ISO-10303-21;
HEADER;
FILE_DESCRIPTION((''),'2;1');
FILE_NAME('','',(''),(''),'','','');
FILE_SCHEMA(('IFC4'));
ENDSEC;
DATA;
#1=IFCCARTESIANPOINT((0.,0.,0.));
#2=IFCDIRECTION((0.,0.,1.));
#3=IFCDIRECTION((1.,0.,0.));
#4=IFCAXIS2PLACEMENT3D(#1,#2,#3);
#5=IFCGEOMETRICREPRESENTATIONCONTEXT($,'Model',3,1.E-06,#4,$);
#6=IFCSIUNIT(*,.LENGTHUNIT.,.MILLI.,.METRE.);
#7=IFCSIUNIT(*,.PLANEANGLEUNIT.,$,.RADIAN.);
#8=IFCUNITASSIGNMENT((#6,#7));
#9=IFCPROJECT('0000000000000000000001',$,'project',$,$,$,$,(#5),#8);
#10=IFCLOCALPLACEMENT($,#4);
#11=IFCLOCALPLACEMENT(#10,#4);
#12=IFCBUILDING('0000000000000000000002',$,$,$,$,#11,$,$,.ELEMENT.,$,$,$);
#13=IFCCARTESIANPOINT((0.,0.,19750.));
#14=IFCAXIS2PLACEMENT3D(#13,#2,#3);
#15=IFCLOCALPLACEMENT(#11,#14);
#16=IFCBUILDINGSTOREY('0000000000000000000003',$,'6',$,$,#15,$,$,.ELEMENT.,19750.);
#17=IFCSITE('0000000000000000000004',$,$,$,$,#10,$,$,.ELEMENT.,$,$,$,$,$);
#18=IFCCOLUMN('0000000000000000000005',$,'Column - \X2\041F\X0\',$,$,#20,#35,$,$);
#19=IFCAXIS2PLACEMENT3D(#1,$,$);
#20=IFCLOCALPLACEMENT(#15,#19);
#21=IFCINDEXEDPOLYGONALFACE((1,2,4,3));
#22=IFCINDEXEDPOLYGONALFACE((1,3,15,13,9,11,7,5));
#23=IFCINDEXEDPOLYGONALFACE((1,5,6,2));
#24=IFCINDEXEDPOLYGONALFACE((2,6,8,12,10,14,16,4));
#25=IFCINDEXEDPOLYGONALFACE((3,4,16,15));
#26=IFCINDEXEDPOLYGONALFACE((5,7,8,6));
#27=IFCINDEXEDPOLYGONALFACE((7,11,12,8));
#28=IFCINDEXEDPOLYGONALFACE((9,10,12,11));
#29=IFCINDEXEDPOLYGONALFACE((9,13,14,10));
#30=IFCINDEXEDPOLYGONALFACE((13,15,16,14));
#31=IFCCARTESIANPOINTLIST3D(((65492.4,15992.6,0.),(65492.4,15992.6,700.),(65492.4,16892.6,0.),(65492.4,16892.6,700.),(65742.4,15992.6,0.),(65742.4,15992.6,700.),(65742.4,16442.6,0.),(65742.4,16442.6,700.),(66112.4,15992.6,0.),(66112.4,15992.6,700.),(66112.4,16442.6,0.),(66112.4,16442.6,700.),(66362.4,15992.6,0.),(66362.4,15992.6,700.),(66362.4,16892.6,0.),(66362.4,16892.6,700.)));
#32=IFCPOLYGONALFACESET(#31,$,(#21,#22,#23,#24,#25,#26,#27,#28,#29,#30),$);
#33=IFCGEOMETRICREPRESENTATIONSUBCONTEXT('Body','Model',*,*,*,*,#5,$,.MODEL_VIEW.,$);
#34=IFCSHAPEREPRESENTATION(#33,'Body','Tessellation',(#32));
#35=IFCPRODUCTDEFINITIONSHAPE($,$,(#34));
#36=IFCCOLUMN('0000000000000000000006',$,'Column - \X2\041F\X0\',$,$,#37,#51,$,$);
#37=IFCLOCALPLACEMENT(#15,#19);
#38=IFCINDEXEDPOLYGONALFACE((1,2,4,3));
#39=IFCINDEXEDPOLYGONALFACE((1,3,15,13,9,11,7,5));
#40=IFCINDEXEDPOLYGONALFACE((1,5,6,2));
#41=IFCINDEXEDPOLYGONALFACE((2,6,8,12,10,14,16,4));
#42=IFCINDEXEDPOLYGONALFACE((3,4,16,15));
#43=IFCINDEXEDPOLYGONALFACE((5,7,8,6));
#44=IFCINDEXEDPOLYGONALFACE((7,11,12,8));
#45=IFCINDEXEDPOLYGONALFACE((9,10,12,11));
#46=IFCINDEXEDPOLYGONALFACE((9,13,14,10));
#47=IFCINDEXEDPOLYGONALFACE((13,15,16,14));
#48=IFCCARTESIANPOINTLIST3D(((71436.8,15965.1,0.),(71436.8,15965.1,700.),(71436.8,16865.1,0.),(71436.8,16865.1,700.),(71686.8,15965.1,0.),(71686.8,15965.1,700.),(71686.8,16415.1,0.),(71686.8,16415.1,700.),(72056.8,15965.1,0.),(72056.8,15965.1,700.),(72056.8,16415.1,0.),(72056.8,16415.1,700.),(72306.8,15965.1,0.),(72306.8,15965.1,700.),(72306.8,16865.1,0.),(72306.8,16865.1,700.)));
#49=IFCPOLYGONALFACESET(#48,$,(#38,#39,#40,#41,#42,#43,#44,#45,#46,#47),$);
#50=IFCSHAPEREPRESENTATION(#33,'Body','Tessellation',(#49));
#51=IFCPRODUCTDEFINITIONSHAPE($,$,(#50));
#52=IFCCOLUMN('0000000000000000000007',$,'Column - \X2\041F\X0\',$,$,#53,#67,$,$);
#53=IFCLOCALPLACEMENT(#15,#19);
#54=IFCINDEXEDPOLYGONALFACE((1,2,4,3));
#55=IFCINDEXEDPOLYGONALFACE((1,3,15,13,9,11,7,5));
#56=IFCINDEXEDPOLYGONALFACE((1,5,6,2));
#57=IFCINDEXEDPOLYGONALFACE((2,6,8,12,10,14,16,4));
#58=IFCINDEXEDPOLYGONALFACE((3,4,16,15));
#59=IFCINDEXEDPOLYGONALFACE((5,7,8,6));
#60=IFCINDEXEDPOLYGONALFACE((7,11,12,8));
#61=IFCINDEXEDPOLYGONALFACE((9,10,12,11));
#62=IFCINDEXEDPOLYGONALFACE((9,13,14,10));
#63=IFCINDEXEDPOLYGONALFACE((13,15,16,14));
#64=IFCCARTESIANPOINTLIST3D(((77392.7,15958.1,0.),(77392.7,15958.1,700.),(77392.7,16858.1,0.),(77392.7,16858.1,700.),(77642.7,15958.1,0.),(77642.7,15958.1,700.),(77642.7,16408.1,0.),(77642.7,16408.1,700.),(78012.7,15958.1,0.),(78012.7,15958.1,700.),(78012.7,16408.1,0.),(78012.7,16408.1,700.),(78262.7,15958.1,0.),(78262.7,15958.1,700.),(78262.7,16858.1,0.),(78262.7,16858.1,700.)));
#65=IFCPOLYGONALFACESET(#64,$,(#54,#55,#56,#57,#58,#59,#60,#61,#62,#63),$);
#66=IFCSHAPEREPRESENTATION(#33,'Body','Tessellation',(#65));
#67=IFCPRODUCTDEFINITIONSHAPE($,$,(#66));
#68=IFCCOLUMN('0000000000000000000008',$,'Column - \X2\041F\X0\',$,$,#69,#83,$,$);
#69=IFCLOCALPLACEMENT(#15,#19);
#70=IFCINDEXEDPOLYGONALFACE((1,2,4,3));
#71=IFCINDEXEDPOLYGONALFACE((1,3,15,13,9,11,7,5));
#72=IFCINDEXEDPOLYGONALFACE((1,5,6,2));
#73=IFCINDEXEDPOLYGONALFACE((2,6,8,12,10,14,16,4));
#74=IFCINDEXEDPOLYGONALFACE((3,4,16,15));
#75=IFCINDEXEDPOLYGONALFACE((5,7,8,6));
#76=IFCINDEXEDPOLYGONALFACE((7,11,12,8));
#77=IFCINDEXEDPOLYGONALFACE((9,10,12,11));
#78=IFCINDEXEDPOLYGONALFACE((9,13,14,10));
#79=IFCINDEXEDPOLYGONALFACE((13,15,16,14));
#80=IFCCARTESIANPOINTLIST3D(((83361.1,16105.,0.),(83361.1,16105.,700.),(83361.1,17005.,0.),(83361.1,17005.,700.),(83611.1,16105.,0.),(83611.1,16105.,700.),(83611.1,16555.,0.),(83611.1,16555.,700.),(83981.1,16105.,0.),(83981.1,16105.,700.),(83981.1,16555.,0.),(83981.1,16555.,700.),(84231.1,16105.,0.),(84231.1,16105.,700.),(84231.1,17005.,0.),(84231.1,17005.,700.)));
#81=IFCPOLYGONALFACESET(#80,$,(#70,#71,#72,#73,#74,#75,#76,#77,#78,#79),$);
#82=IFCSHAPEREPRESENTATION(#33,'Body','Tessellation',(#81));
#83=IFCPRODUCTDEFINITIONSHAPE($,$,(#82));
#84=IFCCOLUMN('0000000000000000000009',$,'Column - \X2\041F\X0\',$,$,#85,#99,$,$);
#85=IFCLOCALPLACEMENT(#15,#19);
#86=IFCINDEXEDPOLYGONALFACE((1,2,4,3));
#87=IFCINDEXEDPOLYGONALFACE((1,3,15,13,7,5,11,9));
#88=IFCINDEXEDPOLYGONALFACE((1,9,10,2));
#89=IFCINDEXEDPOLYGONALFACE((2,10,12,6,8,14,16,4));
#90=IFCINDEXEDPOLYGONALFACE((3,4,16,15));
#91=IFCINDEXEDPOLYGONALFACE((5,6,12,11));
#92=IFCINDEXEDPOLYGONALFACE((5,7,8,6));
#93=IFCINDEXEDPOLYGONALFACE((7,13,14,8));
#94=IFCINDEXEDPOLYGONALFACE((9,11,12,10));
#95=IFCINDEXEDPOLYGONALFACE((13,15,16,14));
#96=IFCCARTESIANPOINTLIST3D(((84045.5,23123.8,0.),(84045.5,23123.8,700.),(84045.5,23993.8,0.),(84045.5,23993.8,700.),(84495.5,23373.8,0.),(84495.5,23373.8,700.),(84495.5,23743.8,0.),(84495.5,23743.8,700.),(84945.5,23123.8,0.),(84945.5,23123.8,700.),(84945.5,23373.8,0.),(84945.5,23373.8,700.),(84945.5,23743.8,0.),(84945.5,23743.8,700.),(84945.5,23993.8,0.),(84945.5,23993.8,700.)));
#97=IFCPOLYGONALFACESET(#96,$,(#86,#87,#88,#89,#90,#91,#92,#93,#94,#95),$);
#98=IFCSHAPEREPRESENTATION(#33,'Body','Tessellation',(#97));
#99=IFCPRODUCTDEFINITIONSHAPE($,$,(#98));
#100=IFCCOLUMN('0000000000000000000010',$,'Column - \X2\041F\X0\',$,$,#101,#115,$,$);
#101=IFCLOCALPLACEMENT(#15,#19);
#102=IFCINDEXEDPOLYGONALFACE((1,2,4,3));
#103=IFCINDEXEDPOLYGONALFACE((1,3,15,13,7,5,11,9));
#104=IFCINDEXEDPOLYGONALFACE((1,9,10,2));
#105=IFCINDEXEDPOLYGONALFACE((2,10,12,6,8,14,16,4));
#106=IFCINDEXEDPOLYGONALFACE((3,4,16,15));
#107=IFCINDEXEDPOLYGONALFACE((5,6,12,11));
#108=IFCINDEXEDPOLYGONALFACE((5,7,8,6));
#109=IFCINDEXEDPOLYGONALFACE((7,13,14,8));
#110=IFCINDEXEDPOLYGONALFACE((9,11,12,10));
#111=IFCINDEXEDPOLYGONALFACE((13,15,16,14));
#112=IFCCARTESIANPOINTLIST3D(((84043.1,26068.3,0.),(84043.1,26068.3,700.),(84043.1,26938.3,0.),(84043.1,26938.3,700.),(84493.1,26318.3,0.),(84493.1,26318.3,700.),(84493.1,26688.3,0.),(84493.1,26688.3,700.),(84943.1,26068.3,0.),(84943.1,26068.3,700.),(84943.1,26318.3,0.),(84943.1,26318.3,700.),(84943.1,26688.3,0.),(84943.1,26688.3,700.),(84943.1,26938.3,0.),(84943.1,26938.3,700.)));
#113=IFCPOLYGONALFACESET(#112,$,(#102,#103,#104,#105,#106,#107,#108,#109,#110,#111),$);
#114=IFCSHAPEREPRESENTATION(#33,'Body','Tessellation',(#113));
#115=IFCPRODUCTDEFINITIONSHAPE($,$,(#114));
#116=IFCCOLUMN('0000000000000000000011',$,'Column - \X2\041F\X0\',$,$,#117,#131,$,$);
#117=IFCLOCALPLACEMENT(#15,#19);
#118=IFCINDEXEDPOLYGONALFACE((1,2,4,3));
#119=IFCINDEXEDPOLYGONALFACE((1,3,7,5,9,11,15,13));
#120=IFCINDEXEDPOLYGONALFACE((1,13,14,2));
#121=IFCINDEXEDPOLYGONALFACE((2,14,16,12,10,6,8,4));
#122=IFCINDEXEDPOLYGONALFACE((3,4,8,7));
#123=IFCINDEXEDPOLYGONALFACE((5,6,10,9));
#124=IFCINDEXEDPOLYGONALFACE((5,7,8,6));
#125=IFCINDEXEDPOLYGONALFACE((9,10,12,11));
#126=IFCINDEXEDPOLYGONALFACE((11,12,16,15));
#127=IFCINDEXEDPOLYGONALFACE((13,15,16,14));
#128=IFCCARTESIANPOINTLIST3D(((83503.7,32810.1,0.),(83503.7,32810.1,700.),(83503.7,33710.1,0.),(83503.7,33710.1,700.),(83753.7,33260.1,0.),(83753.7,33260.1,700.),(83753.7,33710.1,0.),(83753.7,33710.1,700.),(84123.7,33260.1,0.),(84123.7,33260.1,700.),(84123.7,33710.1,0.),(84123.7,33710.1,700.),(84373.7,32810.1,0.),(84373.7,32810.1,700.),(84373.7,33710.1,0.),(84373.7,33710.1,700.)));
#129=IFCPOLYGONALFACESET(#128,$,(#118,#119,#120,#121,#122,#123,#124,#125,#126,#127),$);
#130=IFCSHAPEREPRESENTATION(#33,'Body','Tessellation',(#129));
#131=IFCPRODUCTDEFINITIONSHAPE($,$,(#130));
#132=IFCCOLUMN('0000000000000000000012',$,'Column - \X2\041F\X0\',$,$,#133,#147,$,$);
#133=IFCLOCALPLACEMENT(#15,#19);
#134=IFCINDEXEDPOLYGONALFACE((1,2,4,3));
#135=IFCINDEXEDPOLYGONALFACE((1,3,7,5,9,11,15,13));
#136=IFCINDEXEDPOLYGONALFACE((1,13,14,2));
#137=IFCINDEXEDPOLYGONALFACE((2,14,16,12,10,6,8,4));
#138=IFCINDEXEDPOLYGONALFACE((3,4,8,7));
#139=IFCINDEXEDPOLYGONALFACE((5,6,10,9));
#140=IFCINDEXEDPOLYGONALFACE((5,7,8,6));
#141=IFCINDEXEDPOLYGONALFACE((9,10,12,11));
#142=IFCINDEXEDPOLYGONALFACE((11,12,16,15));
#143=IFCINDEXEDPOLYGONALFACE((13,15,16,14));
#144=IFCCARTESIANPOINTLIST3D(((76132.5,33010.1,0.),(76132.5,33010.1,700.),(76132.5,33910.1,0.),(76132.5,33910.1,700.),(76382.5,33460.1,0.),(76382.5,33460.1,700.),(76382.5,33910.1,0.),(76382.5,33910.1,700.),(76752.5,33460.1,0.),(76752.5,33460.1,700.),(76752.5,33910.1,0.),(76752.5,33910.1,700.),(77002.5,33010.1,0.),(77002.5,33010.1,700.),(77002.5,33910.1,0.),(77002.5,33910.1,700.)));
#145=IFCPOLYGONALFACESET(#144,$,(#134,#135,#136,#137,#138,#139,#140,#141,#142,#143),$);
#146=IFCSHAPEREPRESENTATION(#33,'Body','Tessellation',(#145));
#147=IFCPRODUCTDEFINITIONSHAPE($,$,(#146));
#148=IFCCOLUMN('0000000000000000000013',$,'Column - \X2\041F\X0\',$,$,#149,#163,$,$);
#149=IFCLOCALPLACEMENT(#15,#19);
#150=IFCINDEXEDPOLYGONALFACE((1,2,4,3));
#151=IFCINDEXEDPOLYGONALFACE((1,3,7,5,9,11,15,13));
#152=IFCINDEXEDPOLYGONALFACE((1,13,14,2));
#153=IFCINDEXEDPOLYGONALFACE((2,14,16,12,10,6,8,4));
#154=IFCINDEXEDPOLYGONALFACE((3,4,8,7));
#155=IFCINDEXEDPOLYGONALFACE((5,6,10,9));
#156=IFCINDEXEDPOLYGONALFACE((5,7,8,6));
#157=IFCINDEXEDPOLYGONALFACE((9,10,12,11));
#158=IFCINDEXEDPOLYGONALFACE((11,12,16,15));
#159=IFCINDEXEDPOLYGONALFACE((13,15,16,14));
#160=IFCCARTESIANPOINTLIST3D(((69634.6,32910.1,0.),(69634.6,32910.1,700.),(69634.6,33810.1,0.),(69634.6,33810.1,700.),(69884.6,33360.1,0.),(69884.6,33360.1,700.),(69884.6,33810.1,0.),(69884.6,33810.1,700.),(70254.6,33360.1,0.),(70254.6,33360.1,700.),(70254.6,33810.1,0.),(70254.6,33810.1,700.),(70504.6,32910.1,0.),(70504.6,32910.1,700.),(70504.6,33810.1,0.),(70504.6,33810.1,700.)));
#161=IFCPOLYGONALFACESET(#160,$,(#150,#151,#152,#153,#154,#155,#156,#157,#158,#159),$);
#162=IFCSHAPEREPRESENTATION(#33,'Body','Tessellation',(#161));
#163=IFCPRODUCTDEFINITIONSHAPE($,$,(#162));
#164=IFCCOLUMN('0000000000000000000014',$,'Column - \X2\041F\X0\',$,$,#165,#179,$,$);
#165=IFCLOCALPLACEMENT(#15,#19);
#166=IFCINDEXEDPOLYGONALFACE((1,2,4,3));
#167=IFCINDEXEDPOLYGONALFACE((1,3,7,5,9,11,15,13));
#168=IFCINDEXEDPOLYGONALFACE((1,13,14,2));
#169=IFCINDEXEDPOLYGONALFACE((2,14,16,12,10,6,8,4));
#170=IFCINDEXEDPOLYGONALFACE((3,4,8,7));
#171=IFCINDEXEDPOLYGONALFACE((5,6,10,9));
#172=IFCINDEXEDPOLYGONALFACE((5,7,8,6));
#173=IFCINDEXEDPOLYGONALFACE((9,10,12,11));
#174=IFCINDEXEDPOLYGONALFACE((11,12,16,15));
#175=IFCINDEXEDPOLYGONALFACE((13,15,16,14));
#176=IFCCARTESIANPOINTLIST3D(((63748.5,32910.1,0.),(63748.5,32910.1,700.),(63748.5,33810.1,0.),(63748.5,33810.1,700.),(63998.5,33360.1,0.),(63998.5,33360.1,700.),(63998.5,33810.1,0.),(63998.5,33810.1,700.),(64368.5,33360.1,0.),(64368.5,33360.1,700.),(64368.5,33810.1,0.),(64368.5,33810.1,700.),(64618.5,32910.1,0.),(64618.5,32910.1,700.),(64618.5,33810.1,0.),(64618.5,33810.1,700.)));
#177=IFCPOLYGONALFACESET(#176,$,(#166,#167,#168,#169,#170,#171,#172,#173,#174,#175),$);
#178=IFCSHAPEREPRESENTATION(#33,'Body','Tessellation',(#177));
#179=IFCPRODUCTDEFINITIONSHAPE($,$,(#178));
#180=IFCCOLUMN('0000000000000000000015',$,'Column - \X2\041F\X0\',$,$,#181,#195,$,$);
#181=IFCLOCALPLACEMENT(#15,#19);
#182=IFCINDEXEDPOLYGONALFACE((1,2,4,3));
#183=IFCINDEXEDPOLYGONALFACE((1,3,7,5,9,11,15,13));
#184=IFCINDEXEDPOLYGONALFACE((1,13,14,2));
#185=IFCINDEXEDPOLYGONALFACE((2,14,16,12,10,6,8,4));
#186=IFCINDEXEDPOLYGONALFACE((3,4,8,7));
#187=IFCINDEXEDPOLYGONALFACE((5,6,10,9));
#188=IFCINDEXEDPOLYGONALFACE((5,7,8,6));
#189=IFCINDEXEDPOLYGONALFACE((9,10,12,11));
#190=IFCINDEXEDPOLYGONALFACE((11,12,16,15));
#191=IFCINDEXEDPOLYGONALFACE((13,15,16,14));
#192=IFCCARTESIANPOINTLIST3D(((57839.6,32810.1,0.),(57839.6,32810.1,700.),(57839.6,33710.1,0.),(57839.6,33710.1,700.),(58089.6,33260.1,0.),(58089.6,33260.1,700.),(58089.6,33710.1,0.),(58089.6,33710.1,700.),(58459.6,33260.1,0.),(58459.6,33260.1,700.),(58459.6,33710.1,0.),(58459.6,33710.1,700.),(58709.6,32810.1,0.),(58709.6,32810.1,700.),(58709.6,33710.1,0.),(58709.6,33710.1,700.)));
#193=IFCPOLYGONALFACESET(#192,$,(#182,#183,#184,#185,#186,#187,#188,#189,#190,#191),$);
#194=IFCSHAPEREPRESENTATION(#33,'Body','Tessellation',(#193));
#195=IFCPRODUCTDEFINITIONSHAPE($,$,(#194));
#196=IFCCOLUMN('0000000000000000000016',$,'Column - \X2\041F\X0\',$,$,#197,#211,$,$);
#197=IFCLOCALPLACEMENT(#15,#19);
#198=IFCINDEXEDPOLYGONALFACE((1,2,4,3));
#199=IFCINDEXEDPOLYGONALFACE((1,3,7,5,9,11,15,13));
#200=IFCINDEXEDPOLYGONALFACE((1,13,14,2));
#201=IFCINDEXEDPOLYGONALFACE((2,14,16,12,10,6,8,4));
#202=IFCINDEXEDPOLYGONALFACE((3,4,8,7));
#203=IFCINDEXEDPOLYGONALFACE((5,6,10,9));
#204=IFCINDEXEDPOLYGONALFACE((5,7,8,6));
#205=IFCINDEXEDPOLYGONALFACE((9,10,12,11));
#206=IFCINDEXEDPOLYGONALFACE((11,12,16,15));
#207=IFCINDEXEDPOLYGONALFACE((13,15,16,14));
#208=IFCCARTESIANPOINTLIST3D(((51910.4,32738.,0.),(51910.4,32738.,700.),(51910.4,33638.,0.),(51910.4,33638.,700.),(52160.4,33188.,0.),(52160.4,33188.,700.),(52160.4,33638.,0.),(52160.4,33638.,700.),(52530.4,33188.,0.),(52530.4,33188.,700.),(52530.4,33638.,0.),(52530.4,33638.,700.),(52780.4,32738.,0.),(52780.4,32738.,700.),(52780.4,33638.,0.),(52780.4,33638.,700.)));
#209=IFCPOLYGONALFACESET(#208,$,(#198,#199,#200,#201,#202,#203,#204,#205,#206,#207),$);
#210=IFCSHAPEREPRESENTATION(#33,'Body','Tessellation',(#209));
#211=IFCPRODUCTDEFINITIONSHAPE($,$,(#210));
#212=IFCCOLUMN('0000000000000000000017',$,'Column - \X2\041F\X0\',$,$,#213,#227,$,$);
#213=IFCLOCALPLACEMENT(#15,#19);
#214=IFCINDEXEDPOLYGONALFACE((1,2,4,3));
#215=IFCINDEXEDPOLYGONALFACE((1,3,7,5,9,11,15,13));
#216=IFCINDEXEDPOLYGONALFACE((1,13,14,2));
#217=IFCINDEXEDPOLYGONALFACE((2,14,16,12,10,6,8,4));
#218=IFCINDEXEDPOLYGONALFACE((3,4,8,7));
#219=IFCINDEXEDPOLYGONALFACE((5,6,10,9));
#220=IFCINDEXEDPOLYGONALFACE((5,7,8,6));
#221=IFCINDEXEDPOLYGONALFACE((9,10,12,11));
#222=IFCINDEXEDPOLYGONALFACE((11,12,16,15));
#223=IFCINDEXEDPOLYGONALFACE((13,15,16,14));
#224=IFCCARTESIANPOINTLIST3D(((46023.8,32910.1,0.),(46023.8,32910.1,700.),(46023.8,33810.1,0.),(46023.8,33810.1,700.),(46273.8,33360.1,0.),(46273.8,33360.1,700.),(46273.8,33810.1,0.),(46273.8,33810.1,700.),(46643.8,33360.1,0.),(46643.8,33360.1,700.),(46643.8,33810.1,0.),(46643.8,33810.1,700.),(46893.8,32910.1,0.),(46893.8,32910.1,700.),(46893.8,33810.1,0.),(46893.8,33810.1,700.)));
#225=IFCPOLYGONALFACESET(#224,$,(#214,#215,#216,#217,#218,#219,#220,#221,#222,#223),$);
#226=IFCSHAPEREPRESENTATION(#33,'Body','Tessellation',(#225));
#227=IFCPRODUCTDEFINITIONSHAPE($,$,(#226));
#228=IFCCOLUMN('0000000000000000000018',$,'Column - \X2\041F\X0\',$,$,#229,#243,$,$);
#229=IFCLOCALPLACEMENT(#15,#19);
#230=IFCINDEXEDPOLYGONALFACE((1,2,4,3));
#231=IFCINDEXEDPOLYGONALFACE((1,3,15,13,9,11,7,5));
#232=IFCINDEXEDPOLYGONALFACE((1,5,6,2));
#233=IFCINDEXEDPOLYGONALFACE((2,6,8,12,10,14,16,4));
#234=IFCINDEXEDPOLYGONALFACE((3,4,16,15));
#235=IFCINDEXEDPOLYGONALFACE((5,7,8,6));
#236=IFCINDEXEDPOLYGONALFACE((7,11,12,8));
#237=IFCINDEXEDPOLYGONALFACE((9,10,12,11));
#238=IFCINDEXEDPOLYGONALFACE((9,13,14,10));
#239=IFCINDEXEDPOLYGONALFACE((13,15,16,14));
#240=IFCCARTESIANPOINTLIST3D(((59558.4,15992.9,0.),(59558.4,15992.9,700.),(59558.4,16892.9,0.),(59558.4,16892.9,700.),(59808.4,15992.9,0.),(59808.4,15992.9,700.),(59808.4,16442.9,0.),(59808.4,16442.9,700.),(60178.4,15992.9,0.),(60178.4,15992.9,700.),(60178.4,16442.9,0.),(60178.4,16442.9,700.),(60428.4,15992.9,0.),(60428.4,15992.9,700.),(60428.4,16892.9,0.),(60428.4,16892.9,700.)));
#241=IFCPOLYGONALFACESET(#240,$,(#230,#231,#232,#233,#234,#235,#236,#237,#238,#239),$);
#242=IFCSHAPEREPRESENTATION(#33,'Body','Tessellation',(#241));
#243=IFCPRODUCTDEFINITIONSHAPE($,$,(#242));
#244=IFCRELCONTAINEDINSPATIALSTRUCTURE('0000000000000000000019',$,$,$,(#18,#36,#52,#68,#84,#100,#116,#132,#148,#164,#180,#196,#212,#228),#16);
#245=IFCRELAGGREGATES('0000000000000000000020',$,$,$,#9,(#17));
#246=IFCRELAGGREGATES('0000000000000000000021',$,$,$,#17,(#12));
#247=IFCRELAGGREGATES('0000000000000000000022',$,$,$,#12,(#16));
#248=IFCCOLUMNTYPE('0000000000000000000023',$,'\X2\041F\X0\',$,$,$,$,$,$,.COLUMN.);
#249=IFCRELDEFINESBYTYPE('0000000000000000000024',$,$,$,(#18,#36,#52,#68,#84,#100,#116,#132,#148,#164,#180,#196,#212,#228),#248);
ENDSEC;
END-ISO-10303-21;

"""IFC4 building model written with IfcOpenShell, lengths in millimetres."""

from ifc_helpers import new_model, si_unit, frame, origin_with_axes, place, context, subcontext, project, spatial, line, indexed_curve, outline, extrude, source, transform, mapped, type_object, element, save


model = new_model("IFC4")

# Units and contexts
model_context = context("Model", 3, precision=1e-06, world=origin_with_axes())
body_context = subcontext(model_context, "Body", "Model", "MODEL_VIEW")
ifc_project = project(units=[si_unit("LENGTHUNIT", "METRE", prefix="MILLI"), si_unit("PLANEANGLEUNIT", "RADIAN")], contexts=[model_context])

# Site, building, storey
site_placement = place(None, origin_with_axes())
site = spatial("IfcSite", under=ifc_project, at=site_placement, CompositionType="ELEMENT")
building_placement = place(site_placement, origin_with_axes())
building = spatial("IfcBuilding", under=site, at=building_placement, CompositionType="ELEMENT")
storey_placement = place(building_placement, frame((0.0, 0.0, 19750.0), z_axis=(0.0, 0.0, 1.0), x_axis=(1.0, 0.0, 0.0)))
storey = spatial("IfcBuildingStorey", under=building, at=storey_placement, Name="6", CompositionType="ELEMENT", Elevation=19750.0)

# Columns
column_type = type_object("IfcColumnType", Name="П", PredefinedType="COLUMN")
shared_shape = source(origin_with_axes(), body_context, "Body", "SweptSolid", [
    extrude(outline(indexed_curve([(-450.0, -435.0), (450.0, -435.0), (450.0, -185.0), (0.0, -185.0), (0.0, 185.0), (450.0, 185.0), (450.0, 435.0), (-450.0, 435.0)], segments=[line(1, 2), line(2, 3), line(3, 4), line(4, 5), line(5, 6), line(6, 7), line(7, 8), line(8, 1)])), origin_with_axes(), (0.0, 0.0, 1.0), 700.0),
])
for number, where, z_axis, x_axis, name in (
    (1, (65927.4, 16442.6, 0.0), (0.0, 0.0, 1.0), (0.0, -1.0, 0.0), "Column - П"),
    (2, (71871.8, 16415.1, 0.0), (0.0, 0.0, 1.0), (0.0, -1.0, 0.0), "Column - П"),
    (3, (77827.7, 16408.1, 0.0), (0.0, 0.0, 1.0), (0.0, -1.0, 0.0), "Column - П"),
    (4, (83796.1, 16555.0, 0.0), (0.0, 0.0, 1.0), (0.0, -1.0, 0.0), "Column - П"),
    (5, (84495.5, 23558.8, 0.0), (0.0, 0.0, 1.0), (1.0, 0.0, 0.0), "Column - П"),
    (6, (84493.1, 26503.3, 0.0), (0.0, 0.0, 1.0), (1.0, 0.0, 0.0), "Column - П"),
    (7, (83938.7, 33260.1, 0.0), (0.0, 0.0, 1.0), (0.0, 1.0, 0.0), "Column - П"),
    (8, (76567.5, 33460.1, 0.0), (0.0, 0.0, 1.0), (0.0, 1.0, 0.0), "Column - П"),
    (9, (70069.6, 33360.1, 0.0), (0.0, 0.0, 1.0), (0.0, 1.0, 0.0), "Column - П"),
    (10, (64183.5, 33360.1, 0.0), (0.0, 0.0, 1.0), (0.0, 1.0, 0.0), "Column - П"),
    (11, (58274.6, 33260.1, 0.0), (0.0, 0.0, 1.0), (0.0, 1.0, 0.0), "Column - П"),
    (12, (52345.4, 33188.0, 0.0), (0.0, 0.0, 1.0), (0.0, 1.0, 0.0), "Column - П"),
    (13, (46458.8, 33360.1, 0.0), (0.0, 0.0, 1.0), (0.0, 1.0, 0.0), "Column - П"),
    (14, (59993.4, 16442.9, 0.0), (0.0, 0.0, 1.0), (0.0, -1.0, 0.0), "Column - П"),
):
    element("IfcColumn", number, at=place(storey_placement, frame(where, z_axis=z_axis, x_axis=x_axis)), inside=storey, type_object=column_type, Name=name, context=body_context, shape_type="MappedRepresentation", body=[
        mapped(shared_shape, transform((0.0, 0.0, 0.0), x_axis=(1.0, 0.0, 0.0), y_axis=(0.0, 1.0, 0.0), z_axis=(0.0, 0.0, 1.0), scale=1.0)),
    ])

save(model, "model.ifc")
